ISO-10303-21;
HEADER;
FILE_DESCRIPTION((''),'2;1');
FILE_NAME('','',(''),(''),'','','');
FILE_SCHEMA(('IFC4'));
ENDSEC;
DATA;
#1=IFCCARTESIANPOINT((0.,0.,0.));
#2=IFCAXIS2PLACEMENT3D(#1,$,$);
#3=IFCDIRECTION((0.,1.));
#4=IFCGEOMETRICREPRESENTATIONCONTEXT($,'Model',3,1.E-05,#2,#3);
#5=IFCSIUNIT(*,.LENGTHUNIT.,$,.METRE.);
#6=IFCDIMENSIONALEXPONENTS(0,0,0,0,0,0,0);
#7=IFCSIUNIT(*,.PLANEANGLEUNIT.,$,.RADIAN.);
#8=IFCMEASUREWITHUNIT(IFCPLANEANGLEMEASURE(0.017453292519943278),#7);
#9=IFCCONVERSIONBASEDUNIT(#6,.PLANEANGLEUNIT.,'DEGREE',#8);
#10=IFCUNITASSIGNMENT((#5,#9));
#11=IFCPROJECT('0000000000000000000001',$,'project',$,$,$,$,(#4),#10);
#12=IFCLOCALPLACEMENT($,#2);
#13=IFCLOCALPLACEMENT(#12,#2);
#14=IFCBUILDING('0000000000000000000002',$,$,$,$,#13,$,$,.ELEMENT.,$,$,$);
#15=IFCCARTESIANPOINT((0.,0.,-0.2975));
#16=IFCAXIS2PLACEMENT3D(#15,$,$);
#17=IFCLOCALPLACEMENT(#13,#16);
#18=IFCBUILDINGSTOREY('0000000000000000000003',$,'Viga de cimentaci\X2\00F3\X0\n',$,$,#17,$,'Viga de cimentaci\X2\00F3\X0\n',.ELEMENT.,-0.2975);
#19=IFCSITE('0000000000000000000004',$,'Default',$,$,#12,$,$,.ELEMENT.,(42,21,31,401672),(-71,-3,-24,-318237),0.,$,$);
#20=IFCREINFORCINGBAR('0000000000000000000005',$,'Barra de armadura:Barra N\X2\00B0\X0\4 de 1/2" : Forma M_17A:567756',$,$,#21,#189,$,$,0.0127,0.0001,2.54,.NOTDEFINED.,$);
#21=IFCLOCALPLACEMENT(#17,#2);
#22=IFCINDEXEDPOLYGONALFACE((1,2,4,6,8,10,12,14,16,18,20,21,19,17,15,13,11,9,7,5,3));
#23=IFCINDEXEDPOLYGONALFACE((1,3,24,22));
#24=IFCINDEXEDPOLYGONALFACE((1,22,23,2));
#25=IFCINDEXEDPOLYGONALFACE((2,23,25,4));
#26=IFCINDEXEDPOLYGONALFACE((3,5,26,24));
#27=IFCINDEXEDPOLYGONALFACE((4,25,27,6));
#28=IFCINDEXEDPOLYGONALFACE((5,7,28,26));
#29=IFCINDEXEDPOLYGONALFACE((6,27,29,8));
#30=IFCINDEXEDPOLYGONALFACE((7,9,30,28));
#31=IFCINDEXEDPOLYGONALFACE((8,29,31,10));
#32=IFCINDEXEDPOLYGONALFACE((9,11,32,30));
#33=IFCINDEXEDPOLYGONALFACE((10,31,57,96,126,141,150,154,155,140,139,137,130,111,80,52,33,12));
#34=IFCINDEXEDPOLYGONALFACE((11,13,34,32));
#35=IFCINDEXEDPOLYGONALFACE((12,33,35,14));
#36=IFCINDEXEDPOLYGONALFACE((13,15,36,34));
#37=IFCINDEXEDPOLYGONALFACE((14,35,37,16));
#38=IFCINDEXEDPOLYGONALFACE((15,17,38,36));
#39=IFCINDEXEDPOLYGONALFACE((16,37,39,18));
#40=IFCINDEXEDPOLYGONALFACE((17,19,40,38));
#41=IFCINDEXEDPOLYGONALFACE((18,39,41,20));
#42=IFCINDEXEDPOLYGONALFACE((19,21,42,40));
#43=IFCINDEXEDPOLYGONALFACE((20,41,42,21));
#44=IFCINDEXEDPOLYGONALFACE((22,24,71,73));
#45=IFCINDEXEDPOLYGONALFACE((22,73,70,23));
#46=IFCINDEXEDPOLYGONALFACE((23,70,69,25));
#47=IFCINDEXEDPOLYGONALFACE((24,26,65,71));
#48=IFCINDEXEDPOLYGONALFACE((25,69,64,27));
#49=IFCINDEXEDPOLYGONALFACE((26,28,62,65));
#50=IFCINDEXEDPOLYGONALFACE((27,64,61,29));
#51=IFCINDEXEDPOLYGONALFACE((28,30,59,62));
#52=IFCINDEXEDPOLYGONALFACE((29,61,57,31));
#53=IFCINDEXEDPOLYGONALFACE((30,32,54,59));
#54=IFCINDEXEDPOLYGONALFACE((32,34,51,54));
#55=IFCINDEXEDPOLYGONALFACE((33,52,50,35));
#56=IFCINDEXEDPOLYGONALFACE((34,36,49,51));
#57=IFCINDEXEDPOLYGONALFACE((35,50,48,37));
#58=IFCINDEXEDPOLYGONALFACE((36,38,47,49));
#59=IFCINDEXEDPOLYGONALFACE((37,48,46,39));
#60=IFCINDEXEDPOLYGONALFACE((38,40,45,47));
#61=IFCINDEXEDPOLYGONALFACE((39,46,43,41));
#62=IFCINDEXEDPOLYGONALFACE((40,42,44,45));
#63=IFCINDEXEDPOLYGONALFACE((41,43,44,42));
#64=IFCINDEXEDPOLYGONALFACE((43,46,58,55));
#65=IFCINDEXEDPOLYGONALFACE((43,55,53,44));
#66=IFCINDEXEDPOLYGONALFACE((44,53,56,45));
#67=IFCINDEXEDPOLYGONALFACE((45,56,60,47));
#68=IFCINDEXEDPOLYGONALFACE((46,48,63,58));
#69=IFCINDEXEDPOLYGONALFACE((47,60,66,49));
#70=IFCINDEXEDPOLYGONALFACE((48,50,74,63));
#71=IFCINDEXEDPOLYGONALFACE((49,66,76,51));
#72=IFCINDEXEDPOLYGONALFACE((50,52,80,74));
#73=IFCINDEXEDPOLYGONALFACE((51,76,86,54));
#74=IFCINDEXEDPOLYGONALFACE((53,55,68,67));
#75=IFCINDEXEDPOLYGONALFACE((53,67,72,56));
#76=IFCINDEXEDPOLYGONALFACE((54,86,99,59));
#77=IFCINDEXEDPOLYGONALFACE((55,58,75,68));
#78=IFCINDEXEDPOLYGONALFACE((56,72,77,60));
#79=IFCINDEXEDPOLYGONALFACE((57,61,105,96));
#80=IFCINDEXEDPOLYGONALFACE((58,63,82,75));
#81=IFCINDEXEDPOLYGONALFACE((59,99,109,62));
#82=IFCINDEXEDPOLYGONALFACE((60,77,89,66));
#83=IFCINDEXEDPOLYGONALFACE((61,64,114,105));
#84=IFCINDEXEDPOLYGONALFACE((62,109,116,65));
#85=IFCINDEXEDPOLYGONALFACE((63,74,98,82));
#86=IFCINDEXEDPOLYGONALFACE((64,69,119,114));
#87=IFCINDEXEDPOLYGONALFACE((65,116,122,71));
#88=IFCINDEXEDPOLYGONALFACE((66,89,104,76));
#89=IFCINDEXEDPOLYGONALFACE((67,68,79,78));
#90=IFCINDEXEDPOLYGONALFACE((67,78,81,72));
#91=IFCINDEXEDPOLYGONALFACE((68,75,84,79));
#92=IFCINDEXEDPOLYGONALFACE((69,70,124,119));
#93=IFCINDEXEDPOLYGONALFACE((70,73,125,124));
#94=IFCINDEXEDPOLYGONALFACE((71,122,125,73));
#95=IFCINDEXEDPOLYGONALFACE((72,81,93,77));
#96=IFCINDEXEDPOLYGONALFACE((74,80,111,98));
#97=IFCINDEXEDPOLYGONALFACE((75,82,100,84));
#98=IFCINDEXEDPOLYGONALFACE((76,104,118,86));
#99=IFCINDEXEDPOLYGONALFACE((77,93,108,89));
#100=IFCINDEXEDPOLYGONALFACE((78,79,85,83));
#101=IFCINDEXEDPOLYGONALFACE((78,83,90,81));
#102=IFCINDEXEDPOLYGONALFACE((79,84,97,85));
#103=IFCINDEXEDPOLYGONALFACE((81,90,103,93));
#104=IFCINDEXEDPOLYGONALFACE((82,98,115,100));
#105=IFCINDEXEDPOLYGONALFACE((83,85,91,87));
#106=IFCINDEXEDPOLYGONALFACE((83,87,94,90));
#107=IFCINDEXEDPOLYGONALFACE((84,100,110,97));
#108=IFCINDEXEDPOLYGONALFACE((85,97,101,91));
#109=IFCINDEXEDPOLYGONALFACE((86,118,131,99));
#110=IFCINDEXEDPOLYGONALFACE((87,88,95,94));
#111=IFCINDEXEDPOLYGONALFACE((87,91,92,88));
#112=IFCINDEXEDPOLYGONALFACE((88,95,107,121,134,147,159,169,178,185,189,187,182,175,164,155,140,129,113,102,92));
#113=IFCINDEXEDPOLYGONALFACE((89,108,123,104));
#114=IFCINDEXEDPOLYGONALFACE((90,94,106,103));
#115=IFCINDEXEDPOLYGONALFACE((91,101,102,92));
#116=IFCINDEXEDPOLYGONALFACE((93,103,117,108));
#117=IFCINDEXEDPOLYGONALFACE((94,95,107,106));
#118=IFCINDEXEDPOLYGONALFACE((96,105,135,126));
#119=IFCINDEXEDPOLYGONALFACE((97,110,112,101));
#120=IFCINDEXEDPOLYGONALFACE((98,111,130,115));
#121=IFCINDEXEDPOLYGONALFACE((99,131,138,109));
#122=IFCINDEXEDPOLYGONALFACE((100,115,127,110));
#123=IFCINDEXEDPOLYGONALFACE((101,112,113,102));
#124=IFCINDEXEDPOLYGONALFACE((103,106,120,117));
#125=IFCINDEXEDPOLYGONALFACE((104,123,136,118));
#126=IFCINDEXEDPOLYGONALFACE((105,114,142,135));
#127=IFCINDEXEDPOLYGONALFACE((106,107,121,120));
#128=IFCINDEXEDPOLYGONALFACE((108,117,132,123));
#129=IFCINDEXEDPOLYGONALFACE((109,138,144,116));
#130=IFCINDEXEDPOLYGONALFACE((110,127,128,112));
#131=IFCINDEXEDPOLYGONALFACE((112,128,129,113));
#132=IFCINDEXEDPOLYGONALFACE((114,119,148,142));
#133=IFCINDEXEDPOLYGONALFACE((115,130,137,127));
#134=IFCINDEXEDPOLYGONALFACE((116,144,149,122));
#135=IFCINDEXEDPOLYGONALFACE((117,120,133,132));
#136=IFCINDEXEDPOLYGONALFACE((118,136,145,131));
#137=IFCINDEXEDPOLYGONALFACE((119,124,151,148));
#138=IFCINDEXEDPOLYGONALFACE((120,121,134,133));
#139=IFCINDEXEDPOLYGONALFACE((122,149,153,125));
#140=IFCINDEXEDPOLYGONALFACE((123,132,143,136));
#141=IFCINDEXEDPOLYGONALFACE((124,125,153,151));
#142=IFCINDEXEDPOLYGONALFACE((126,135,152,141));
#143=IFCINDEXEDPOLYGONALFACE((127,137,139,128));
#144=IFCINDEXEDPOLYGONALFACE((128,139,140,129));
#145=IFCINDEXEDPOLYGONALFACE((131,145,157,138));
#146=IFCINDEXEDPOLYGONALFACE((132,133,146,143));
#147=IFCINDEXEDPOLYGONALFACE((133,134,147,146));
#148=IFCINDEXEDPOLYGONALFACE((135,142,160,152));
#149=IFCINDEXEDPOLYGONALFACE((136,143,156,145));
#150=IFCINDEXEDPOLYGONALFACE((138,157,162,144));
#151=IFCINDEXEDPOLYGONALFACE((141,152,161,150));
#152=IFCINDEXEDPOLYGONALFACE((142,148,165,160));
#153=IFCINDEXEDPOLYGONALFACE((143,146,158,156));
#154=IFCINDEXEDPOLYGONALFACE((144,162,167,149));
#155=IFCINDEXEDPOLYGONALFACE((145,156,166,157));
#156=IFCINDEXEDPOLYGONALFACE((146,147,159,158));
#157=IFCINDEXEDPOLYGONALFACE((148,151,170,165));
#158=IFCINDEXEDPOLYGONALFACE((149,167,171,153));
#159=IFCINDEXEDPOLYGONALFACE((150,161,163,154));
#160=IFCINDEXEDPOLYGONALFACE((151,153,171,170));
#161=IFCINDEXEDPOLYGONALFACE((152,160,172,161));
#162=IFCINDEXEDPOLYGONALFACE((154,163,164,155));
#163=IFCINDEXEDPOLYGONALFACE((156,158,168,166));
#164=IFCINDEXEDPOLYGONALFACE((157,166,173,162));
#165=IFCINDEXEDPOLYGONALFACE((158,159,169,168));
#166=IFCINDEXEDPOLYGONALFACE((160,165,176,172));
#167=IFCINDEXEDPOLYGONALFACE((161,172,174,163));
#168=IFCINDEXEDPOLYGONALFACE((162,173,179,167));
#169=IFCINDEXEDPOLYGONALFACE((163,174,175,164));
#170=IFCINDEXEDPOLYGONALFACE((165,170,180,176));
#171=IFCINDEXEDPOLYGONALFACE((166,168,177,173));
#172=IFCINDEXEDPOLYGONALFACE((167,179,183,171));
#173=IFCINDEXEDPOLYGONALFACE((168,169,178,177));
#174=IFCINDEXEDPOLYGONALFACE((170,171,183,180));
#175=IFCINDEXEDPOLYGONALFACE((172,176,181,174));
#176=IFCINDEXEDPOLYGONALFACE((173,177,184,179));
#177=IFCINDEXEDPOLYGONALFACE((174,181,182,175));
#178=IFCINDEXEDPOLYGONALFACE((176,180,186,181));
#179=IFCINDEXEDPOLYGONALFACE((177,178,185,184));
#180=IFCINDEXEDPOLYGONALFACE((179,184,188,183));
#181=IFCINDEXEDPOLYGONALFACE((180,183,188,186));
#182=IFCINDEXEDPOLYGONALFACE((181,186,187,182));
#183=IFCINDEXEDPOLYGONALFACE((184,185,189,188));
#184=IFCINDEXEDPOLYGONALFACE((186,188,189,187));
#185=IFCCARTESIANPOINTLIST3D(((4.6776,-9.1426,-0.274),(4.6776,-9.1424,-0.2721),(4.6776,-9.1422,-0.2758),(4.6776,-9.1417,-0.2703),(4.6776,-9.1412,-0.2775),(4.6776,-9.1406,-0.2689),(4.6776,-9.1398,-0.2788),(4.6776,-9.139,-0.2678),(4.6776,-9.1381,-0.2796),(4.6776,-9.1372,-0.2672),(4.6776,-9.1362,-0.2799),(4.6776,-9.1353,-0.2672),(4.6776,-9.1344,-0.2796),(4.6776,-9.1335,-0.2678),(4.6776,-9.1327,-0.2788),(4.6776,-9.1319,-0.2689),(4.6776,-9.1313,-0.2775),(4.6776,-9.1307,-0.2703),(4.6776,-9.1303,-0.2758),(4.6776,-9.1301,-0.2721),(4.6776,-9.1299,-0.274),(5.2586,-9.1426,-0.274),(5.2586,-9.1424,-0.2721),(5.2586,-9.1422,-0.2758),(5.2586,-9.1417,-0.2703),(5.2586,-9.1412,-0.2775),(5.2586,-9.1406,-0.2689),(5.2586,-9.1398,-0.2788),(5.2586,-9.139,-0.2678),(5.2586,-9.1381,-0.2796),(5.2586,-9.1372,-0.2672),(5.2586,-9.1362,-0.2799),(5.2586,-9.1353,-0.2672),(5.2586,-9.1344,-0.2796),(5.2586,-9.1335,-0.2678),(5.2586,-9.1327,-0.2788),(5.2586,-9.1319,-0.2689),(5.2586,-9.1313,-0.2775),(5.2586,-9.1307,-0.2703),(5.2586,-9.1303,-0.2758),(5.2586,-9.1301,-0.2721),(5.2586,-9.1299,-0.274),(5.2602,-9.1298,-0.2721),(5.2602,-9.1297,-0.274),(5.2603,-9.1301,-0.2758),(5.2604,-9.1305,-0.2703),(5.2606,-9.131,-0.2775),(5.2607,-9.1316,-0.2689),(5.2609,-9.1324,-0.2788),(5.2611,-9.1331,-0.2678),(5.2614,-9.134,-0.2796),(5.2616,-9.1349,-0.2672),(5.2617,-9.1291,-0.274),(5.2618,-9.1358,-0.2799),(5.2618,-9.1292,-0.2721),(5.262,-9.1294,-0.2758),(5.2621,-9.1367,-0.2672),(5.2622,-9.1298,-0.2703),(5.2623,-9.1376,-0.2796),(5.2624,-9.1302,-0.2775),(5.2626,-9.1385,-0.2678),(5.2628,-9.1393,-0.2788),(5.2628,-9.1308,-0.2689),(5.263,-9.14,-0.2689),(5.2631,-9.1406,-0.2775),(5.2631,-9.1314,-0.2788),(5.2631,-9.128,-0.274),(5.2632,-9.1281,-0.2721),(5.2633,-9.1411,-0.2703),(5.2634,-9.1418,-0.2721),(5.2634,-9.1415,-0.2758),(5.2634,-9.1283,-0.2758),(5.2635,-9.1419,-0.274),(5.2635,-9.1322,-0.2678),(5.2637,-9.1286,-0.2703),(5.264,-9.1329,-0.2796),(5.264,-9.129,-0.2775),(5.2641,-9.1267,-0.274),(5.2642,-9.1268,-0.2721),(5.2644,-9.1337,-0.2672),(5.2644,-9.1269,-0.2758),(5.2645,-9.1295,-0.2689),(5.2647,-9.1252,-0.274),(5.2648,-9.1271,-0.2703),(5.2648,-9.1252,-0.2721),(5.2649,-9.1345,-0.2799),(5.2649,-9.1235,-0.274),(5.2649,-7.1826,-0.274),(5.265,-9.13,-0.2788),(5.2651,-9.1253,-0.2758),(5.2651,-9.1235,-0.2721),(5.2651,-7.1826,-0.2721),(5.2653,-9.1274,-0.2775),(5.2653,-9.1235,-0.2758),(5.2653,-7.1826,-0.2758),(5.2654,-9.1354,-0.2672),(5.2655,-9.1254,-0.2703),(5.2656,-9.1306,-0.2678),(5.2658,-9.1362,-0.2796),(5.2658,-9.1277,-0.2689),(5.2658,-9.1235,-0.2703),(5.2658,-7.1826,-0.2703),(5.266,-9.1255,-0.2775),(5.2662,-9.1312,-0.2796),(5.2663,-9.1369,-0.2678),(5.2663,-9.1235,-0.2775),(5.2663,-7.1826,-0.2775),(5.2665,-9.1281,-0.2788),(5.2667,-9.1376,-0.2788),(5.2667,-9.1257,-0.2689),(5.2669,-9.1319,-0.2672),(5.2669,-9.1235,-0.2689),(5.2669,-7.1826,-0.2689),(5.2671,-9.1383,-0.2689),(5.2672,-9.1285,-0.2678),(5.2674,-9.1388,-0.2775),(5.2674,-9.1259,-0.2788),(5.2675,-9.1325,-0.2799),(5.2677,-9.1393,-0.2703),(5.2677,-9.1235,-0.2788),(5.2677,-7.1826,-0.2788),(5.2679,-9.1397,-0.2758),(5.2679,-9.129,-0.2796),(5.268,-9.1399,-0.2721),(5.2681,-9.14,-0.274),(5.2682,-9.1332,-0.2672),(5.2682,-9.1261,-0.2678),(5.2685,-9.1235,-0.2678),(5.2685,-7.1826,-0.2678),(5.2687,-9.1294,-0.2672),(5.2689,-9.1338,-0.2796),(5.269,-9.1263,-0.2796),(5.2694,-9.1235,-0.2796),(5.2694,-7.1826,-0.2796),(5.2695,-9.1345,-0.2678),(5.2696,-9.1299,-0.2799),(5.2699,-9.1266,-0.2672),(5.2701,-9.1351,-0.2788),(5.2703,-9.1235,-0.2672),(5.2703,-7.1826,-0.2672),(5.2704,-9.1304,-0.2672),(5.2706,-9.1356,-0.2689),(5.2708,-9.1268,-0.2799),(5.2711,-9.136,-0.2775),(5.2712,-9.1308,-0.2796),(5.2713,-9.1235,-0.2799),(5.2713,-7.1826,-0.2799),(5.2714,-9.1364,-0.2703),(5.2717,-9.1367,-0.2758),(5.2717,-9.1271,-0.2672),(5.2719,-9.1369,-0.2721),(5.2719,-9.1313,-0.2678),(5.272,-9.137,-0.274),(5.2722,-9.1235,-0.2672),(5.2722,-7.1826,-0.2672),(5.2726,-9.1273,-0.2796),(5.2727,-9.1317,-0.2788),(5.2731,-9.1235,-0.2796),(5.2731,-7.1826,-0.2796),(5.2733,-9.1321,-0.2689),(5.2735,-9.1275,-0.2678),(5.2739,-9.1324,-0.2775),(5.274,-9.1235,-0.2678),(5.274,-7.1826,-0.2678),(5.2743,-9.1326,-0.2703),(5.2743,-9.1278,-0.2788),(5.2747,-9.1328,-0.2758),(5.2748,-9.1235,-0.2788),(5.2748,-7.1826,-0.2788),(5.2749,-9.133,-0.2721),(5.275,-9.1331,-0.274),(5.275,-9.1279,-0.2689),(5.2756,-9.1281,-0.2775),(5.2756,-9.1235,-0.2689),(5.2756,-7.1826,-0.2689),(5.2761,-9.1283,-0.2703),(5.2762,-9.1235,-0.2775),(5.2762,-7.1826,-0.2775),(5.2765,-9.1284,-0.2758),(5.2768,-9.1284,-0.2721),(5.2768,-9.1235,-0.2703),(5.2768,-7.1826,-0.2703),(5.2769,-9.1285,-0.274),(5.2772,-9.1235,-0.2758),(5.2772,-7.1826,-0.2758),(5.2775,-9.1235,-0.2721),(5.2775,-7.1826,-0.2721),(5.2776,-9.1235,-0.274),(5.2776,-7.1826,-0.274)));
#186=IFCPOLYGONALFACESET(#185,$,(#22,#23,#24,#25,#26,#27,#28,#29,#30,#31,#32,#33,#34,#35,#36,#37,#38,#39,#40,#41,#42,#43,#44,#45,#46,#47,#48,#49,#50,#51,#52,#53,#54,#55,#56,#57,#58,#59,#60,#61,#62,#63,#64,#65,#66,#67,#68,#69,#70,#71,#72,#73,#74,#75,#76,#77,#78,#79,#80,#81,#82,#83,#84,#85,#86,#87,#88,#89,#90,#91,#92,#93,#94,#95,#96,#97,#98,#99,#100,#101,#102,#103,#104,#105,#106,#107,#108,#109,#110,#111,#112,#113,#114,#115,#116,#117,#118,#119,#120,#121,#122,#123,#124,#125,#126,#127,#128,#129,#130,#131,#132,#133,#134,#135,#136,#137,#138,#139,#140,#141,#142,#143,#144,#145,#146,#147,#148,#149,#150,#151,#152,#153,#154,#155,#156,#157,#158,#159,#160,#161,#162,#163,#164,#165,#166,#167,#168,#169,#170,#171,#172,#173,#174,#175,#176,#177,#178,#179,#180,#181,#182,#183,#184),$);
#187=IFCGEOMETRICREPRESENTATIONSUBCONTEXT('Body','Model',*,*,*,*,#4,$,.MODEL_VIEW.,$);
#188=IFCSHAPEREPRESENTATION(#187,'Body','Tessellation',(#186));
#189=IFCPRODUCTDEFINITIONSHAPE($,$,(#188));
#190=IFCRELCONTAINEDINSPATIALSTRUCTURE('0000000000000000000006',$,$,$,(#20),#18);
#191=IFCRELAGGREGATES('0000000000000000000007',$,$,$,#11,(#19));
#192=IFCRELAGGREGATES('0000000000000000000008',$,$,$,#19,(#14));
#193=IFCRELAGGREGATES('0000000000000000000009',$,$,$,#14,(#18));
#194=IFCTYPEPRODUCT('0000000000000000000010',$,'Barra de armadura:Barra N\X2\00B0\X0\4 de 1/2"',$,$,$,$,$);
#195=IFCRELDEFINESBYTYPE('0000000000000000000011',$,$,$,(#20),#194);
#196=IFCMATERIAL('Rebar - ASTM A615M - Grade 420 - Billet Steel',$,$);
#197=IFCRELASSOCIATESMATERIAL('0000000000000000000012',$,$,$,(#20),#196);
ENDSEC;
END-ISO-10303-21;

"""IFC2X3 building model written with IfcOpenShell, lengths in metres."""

from ifc_helpers import new_model, entity, si_unit, converted_unit, direction, frame, origin, place, context, subcontext, project, spatial, material, type_object, element, save


model = new_model("IFC2X3")

# Units and contexts
model_context = context("Model", 3, precision=1e-05, world=origin(), true_north=direction((0.0, 1.0)))
body_context = subcontext(model_context, "Body", "Model", "MODEL_VIEW")
ifc_project = project(units=[si_unit("LENGTHUNIT", "METRE"), converted_unit("PLANEANGLEUNIT", "DEGREE", entity("IfcPlaneAngleMeasure", 0.017453292519943278), si_unit("PLANEANGLEUNIT", "RADIAN"), dimensions=[0, 0, 0, 0, 0, 0, 0])], contexts=[model_context])

# Site, building, storey
site_placement = place(None, origin())
site = spatial("IfcSite", under=ifc_project, at=site_placement, Name="Default", CompositionType="ELEMENT", RefLatitude=(42, 21, 31, 401672), RefLongitude=(-71, -3, -24, -318237), RefElevation=0.0)
building_placement = place(site_placement, origin())
building = spatial("IfcBuilding", under=site, at=building_placement, CompositionType="ELEMENT")
storey_placement = place(building_placement, frame((0.0, 0.0, -0.2975)))
storey = spatial("IfcBuildingStorey", under=building, at=storey_placement, Name="Viga de cimentación", LongName="Viga de cimentación", CompositionType="ELEMENT", Elevation=-0.2975)

# Reinforcing bar
ifc_material = material(Name="Rebar - ASTM A615M - Grade 420 - Billet Steel")
type_product_1 = type_object("IfcTypeProduct", Name="Barra de armadura:Barra N°4 de 1/2\"")
reinforcing_bar_1_placement = place(storey_placement, origin())
element("IfcReinforcingBar", 1, at=reinforcing_bar_1_placement, inside=storey, type_object=type_product_1, material=ifc_material, Name="Barra de armadura:Barra N°4 de 1/2\" : Forma M_17A:567756", BarLength=2.54, BarRole="NOTDEFINED", CrossSectionArea=0.0001, NominalDiameter=0.0127, context=body_context, shape_type="AdvancedSweptSolid", body=[
    entity("IfcSweptDiskSolid", entity("IfcCompositeCurve", [entity("IfcCompositeCurveSegment", "CONTINUOUS", True, entity("IfcPolyline", [entity("IfcCartesianPoint", [5.2713, -7.1826, -0.2735]), entity("IfcCartesianPoint", [5.2713, -9.1235, -0.2735])])), entity("IfcCompositeCurveSegment", "CONTINUOUS", True, entity("IfcTrimmedCurve", entity("IfcCircle", entity("IfcAxis2Placement3D", entity("IfcCartesianPoint", [5.2586, -9.1235, -0.2735]), entity("IfcDirection", [0.0, 0.0, -1.0]), entity("IfcDirection", [0.0, -1.0, 0.0])), 0.0127), [entity("IfcParameterValue", 270.0)], [entity("IfcParameterValue", 360.0)], True, "PARAMETER")), entity("IfcCompositeCurveSegment", "CONTINUOUS", True, entity("IfcPolyline", [entity("IfcCartesianPoint", [5.2586, -9.1362, -0.2735]), entity("IfcCartesianPoint", [4.6776, -9.1362, -0.2735])]))], False), 0.0063, None, 0.0, 92.0),
])

save(model, "model.ifc")
